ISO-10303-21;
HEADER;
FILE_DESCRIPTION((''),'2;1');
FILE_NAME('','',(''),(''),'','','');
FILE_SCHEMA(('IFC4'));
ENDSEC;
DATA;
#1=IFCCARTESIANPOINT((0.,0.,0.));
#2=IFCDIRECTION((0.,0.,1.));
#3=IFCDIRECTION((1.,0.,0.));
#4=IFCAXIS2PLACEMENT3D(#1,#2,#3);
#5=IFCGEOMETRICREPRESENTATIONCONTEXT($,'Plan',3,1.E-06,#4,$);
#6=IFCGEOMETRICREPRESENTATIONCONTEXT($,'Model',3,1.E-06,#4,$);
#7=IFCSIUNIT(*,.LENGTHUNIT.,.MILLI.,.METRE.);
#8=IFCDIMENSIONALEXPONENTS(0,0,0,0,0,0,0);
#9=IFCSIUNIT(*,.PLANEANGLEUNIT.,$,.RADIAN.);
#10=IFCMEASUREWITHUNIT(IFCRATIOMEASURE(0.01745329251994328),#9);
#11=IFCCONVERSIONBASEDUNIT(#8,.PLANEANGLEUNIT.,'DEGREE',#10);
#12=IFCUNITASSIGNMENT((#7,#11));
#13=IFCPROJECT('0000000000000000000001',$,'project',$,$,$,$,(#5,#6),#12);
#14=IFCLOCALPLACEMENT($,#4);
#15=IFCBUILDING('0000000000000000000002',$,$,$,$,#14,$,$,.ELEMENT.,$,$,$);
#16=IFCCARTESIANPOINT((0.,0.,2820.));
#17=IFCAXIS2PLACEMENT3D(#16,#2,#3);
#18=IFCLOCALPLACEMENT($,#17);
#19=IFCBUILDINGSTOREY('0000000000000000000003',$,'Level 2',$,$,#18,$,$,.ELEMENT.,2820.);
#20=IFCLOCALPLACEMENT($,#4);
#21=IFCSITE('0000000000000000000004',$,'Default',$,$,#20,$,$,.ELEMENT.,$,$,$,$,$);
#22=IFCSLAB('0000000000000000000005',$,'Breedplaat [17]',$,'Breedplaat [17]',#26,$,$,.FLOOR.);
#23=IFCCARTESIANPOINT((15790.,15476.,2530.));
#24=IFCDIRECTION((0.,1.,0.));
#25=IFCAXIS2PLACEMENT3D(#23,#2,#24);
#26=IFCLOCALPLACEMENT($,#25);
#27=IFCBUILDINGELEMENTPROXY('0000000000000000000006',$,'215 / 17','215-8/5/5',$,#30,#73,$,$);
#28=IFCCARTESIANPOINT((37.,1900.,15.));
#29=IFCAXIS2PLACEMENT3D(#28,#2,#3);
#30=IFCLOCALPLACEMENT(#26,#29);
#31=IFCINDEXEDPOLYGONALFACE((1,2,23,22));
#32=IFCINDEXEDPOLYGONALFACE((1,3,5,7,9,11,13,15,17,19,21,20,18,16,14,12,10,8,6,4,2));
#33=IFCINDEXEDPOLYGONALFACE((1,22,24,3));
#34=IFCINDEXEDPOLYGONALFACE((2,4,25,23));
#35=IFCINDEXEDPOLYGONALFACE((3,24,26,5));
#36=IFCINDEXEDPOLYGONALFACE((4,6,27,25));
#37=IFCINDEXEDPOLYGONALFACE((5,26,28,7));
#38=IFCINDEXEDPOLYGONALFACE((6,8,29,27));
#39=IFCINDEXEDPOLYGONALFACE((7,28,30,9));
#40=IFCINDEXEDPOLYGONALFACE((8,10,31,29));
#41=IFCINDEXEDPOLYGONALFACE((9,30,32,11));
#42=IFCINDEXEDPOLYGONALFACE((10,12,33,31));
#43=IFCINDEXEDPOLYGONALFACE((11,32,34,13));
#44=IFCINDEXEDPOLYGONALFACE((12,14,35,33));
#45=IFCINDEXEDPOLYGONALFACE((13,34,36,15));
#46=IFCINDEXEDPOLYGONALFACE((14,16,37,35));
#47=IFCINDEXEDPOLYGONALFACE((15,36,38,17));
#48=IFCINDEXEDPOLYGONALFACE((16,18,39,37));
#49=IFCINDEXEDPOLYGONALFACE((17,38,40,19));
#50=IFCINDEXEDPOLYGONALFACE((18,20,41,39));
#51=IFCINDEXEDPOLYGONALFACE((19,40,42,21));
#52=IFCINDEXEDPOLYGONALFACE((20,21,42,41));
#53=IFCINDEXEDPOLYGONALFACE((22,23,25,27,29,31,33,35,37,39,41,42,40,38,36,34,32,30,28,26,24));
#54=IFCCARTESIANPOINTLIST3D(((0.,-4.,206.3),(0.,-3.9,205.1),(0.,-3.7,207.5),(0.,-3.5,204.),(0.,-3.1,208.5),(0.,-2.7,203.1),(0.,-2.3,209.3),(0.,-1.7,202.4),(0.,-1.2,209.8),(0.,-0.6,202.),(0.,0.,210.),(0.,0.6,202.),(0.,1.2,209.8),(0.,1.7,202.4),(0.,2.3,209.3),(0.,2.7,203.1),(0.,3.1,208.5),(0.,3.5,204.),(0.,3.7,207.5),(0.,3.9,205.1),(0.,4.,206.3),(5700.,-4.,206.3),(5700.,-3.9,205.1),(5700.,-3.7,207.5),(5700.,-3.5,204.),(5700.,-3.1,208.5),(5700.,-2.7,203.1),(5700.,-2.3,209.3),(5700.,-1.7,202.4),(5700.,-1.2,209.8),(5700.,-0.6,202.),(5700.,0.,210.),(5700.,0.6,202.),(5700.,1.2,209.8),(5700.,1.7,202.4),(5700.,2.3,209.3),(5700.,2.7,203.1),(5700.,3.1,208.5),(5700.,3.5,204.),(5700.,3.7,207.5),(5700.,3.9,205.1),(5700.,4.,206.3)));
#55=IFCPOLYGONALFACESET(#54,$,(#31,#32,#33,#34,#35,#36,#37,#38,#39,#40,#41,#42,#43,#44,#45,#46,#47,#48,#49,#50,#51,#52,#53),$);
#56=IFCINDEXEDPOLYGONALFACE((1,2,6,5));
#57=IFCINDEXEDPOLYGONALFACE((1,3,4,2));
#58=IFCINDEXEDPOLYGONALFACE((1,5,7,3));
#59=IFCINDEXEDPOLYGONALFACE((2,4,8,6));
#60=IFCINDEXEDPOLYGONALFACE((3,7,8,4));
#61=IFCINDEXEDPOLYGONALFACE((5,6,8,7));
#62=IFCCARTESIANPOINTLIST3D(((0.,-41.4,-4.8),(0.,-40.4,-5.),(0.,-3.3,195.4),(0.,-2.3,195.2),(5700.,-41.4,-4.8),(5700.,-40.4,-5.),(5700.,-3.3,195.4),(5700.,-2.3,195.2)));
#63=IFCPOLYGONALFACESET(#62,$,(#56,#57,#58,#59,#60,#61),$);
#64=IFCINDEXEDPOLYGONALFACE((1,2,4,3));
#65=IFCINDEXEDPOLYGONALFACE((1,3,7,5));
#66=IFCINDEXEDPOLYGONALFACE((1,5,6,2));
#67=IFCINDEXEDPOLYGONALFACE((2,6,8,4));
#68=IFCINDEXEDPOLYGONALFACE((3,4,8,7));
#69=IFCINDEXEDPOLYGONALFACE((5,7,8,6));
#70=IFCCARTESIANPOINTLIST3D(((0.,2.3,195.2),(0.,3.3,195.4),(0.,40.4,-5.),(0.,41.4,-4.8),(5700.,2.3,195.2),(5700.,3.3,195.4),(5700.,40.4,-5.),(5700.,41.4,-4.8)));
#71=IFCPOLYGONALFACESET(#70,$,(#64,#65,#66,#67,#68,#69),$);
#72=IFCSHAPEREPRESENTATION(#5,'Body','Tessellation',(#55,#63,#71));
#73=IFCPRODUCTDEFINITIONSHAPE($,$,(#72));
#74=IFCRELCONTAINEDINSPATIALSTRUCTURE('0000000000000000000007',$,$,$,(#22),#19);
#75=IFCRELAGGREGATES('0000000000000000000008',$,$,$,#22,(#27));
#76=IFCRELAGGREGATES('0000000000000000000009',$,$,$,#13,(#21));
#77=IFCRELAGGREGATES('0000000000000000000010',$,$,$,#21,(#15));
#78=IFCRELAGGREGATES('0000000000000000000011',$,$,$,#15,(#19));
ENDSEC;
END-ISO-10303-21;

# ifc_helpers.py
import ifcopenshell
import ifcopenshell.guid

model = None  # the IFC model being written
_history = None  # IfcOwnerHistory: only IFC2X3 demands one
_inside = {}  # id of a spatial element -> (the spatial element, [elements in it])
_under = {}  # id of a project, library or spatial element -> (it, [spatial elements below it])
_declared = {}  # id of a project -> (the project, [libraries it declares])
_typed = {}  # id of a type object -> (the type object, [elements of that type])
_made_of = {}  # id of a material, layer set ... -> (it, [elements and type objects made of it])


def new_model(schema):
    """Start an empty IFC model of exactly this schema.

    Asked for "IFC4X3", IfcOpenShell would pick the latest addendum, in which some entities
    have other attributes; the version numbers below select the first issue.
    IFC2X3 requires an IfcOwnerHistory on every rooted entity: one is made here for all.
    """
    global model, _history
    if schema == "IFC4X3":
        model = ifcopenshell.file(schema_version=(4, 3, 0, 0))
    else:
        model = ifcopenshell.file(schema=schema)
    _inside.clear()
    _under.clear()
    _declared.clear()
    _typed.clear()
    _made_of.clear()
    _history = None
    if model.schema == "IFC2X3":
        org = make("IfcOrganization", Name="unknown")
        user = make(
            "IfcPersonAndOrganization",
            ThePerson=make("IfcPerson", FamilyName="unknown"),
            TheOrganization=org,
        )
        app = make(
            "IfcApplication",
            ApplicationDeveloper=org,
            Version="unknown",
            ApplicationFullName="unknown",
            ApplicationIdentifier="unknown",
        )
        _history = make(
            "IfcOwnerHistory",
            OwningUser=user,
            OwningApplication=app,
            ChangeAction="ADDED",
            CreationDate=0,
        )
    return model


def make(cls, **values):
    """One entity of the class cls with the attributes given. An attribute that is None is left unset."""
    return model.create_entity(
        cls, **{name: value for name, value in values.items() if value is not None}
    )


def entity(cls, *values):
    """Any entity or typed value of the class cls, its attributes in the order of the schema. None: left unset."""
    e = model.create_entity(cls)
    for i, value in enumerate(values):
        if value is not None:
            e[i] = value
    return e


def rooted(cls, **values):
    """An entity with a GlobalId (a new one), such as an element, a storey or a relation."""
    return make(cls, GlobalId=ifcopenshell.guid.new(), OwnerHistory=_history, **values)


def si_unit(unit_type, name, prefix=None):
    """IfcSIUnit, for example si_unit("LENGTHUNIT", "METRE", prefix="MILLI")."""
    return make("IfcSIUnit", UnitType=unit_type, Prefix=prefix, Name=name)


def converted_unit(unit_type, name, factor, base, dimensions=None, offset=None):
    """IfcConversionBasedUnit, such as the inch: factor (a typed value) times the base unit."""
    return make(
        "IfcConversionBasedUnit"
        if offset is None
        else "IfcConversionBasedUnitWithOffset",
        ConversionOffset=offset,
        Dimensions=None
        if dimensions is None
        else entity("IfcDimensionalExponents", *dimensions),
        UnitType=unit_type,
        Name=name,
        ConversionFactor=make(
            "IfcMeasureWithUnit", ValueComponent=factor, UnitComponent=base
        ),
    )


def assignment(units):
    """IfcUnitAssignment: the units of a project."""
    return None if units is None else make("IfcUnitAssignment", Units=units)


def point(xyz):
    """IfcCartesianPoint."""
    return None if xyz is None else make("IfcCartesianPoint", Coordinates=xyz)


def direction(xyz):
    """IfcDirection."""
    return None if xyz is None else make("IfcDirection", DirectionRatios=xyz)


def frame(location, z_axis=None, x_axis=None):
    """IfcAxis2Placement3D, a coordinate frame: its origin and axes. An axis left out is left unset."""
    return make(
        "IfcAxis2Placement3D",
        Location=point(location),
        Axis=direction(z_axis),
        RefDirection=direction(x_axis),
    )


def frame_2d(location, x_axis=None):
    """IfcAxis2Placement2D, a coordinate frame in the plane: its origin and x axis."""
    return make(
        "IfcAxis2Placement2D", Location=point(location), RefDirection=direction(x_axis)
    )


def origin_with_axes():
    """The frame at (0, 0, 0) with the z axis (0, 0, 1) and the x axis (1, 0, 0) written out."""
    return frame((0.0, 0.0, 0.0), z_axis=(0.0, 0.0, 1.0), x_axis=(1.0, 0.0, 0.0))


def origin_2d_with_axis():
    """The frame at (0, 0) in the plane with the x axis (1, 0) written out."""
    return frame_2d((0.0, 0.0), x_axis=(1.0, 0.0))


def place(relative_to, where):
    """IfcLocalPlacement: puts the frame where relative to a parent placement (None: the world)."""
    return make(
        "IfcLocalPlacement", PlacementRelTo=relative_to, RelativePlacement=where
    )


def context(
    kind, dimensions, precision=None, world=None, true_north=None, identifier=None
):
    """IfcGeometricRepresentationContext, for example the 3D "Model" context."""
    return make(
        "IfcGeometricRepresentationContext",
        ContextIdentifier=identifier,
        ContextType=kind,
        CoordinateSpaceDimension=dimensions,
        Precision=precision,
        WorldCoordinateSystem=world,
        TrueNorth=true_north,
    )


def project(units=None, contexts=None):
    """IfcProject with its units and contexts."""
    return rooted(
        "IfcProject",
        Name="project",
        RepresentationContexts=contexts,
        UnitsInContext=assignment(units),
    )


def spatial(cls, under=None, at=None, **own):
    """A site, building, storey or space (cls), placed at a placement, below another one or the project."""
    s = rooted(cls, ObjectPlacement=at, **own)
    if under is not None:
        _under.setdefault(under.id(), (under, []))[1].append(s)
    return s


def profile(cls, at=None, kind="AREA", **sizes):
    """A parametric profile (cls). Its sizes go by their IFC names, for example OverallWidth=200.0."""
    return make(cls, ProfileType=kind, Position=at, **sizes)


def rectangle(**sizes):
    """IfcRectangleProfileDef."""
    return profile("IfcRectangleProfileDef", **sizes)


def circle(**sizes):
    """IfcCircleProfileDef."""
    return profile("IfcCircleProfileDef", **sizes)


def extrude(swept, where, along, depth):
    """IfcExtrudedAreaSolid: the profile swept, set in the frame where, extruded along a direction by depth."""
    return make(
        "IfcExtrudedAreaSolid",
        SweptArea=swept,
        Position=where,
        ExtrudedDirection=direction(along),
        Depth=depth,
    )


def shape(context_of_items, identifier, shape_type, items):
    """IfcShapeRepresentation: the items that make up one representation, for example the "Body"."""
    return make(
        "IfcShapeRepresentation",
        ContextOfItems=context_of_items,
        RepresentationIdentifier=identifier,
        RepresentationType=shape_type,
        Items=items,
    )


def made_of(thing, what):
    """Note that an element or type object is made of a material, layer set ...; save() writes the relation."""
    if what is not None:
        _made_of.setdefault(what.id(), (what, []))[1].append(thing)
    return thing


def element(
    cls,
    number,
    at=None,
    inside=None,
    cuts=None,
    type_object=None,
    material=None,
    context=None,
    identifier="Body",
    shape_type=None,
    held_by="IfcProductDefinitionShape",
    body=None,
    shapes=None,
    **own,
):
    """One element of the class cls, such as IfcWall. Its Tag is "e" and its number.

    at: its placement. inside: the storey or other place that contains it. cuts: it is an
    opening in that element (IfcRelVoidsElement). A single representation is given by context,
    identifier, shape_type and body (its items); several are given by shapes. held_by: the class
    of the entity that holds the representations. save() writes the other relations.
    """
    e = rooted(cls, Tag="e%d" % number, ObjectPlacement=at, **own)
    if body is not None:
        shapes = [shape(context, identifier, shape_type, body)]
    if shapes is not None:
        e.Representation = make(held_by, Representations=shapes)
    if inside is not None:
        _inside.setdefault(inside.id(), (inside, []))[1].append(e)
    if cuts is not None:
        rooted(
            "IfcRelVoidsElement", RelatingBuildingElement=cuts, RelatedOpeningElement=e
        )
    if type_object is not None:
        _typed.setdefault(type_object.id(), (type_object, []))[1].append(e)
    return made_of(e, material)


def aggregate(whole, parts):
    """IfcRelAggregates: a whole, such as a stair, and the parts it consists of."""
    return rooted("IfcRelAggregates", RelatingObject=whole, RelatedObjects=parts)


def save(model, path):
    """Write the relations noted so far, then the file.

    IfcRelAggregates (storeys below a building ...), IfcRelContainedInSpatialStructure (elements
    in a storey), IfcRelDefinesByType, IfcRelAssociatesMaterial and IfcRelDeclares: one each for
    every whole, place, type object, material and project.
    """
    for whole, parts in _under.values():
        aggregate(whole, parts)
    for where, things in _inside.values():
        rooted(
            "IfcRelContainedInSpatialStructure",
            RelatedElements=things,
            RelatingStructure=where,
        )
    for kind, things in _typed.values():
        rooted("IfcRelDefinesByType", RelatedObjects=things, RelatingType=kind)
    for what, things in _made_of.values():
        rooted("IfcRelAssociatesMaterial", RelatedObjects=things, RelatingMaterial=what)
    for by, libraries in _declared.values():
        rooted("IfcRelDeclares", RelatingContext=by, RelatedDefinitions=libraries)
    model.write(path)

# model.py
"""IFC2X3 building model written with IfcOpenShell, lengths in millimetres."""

from ifc_helpers import new_model, entity, si_unit, converted_unit, frame, origin_with_axes, origin_2d_with_axis, place, context, project, spatial, rectangle, circle, extrude, element, aggregate, save


model = new_model("IFC2X3")

# Units and contexts
plan_context = context("Plan", 3, precision=1e-06, world=origin_with_axes())
model_context = context("Model", 3, precision=1e-06, world=origin_with_axes())
ifc_project = project(units=[si_unit("LENGTHUNIT", "METRE", prefix="MILLI"), converted_unit("PLANEANGLEUNIT", "DEGREE", entity("IfcRatioMeasure", 0.01745329251994328), si_unit("PLANEANGLEUNIT", "RADIAN"), dimensions=[0, 0, 0, 0, 0, 0, 0])], contexts=[plan_context, model_context])

# Site, building, storey
site_placement = place(None, origin_with_axes())
site = spatial("IfcSite", under=ifc_project, at=site_placement, Name="Default", CompositionType="ELEMENT")
building_placement = place(None, origin_with_axes())
building = spatial("IfcBuilding", under=site, at=building_placement, CompositionType="ELEMENT")
storey_placement = place(None, frame((0.0, 0.0, 2820.0), z_axis=(0.0, 0.0, 1.0), x_axis=(1.0, 0.0, 0.0)))
storey = spatial("IfcBuildingStorey", under=building, at=storey_placement, Name="Level 2", CompositionType="ELEMENT", Elevation=2820.0)

# Slab, building element proxy
slab_1_placement = place(None, frame((15790.0, 15476.0, 2530.0), z_axis=(0.0, 0.0, 1.0), x_axis=(0.0, 1.0, 0.0)))
slab_1 = element("IfcSlab", 1, at=slab_1_placement, inside=storey, Name="Breedplaat [17]", ObjectType="Breedplaat [17]", PredefinedType="FLOOR")
proxy_1_placement = place(slab_1_placement, frame((37.0, 1900.0, 15.0), z_axis=(0.0, 0.0, 1.0), x_axis=(1.0, 0.0, 0.0)))
proxy_1 = element("IfcBuildingElementProxy", 2, at=proxy_1_placement, Name="215 / 17", Description="215-8/5/5", context=plan_context, shape_type="SweptSolid", body=[
    extrude(circle(Radius=4.0, at=origin_2d_with_axis()), frame((0.0, 0.0, 206.0), z_axis=(1.0, 0.0, 0.0), x_axis=(0.0, 0.0, 1.0)), (0.0, 0.0, 1.0), 5700.0),
    extrude(rectangle(XDim=203.8, YDim=1.0, at=origin_2d_with_axis()), frame((0.0, -21.9, 95.2), z_axis=(1.0, 0.0, 0.0), x_axis=(0.0, 0.187112, 0.982339)), (0.0, 0.0, 1.0), 5700.0),
    extrude(rectangle(XDim=203.8, YDim=1.0, at=origin_2d_with_axis()), frame((0.0, 21.9, 95.2), z_axis=(1.0, 0.0, 0.0), x_axis=(0.0, -0.187112, 0.982339)), (0.0, 0.0, 1.0), 5700.0),
])
aggregate(slab_1, [proxy_1])

save(model, "model.ifc")
